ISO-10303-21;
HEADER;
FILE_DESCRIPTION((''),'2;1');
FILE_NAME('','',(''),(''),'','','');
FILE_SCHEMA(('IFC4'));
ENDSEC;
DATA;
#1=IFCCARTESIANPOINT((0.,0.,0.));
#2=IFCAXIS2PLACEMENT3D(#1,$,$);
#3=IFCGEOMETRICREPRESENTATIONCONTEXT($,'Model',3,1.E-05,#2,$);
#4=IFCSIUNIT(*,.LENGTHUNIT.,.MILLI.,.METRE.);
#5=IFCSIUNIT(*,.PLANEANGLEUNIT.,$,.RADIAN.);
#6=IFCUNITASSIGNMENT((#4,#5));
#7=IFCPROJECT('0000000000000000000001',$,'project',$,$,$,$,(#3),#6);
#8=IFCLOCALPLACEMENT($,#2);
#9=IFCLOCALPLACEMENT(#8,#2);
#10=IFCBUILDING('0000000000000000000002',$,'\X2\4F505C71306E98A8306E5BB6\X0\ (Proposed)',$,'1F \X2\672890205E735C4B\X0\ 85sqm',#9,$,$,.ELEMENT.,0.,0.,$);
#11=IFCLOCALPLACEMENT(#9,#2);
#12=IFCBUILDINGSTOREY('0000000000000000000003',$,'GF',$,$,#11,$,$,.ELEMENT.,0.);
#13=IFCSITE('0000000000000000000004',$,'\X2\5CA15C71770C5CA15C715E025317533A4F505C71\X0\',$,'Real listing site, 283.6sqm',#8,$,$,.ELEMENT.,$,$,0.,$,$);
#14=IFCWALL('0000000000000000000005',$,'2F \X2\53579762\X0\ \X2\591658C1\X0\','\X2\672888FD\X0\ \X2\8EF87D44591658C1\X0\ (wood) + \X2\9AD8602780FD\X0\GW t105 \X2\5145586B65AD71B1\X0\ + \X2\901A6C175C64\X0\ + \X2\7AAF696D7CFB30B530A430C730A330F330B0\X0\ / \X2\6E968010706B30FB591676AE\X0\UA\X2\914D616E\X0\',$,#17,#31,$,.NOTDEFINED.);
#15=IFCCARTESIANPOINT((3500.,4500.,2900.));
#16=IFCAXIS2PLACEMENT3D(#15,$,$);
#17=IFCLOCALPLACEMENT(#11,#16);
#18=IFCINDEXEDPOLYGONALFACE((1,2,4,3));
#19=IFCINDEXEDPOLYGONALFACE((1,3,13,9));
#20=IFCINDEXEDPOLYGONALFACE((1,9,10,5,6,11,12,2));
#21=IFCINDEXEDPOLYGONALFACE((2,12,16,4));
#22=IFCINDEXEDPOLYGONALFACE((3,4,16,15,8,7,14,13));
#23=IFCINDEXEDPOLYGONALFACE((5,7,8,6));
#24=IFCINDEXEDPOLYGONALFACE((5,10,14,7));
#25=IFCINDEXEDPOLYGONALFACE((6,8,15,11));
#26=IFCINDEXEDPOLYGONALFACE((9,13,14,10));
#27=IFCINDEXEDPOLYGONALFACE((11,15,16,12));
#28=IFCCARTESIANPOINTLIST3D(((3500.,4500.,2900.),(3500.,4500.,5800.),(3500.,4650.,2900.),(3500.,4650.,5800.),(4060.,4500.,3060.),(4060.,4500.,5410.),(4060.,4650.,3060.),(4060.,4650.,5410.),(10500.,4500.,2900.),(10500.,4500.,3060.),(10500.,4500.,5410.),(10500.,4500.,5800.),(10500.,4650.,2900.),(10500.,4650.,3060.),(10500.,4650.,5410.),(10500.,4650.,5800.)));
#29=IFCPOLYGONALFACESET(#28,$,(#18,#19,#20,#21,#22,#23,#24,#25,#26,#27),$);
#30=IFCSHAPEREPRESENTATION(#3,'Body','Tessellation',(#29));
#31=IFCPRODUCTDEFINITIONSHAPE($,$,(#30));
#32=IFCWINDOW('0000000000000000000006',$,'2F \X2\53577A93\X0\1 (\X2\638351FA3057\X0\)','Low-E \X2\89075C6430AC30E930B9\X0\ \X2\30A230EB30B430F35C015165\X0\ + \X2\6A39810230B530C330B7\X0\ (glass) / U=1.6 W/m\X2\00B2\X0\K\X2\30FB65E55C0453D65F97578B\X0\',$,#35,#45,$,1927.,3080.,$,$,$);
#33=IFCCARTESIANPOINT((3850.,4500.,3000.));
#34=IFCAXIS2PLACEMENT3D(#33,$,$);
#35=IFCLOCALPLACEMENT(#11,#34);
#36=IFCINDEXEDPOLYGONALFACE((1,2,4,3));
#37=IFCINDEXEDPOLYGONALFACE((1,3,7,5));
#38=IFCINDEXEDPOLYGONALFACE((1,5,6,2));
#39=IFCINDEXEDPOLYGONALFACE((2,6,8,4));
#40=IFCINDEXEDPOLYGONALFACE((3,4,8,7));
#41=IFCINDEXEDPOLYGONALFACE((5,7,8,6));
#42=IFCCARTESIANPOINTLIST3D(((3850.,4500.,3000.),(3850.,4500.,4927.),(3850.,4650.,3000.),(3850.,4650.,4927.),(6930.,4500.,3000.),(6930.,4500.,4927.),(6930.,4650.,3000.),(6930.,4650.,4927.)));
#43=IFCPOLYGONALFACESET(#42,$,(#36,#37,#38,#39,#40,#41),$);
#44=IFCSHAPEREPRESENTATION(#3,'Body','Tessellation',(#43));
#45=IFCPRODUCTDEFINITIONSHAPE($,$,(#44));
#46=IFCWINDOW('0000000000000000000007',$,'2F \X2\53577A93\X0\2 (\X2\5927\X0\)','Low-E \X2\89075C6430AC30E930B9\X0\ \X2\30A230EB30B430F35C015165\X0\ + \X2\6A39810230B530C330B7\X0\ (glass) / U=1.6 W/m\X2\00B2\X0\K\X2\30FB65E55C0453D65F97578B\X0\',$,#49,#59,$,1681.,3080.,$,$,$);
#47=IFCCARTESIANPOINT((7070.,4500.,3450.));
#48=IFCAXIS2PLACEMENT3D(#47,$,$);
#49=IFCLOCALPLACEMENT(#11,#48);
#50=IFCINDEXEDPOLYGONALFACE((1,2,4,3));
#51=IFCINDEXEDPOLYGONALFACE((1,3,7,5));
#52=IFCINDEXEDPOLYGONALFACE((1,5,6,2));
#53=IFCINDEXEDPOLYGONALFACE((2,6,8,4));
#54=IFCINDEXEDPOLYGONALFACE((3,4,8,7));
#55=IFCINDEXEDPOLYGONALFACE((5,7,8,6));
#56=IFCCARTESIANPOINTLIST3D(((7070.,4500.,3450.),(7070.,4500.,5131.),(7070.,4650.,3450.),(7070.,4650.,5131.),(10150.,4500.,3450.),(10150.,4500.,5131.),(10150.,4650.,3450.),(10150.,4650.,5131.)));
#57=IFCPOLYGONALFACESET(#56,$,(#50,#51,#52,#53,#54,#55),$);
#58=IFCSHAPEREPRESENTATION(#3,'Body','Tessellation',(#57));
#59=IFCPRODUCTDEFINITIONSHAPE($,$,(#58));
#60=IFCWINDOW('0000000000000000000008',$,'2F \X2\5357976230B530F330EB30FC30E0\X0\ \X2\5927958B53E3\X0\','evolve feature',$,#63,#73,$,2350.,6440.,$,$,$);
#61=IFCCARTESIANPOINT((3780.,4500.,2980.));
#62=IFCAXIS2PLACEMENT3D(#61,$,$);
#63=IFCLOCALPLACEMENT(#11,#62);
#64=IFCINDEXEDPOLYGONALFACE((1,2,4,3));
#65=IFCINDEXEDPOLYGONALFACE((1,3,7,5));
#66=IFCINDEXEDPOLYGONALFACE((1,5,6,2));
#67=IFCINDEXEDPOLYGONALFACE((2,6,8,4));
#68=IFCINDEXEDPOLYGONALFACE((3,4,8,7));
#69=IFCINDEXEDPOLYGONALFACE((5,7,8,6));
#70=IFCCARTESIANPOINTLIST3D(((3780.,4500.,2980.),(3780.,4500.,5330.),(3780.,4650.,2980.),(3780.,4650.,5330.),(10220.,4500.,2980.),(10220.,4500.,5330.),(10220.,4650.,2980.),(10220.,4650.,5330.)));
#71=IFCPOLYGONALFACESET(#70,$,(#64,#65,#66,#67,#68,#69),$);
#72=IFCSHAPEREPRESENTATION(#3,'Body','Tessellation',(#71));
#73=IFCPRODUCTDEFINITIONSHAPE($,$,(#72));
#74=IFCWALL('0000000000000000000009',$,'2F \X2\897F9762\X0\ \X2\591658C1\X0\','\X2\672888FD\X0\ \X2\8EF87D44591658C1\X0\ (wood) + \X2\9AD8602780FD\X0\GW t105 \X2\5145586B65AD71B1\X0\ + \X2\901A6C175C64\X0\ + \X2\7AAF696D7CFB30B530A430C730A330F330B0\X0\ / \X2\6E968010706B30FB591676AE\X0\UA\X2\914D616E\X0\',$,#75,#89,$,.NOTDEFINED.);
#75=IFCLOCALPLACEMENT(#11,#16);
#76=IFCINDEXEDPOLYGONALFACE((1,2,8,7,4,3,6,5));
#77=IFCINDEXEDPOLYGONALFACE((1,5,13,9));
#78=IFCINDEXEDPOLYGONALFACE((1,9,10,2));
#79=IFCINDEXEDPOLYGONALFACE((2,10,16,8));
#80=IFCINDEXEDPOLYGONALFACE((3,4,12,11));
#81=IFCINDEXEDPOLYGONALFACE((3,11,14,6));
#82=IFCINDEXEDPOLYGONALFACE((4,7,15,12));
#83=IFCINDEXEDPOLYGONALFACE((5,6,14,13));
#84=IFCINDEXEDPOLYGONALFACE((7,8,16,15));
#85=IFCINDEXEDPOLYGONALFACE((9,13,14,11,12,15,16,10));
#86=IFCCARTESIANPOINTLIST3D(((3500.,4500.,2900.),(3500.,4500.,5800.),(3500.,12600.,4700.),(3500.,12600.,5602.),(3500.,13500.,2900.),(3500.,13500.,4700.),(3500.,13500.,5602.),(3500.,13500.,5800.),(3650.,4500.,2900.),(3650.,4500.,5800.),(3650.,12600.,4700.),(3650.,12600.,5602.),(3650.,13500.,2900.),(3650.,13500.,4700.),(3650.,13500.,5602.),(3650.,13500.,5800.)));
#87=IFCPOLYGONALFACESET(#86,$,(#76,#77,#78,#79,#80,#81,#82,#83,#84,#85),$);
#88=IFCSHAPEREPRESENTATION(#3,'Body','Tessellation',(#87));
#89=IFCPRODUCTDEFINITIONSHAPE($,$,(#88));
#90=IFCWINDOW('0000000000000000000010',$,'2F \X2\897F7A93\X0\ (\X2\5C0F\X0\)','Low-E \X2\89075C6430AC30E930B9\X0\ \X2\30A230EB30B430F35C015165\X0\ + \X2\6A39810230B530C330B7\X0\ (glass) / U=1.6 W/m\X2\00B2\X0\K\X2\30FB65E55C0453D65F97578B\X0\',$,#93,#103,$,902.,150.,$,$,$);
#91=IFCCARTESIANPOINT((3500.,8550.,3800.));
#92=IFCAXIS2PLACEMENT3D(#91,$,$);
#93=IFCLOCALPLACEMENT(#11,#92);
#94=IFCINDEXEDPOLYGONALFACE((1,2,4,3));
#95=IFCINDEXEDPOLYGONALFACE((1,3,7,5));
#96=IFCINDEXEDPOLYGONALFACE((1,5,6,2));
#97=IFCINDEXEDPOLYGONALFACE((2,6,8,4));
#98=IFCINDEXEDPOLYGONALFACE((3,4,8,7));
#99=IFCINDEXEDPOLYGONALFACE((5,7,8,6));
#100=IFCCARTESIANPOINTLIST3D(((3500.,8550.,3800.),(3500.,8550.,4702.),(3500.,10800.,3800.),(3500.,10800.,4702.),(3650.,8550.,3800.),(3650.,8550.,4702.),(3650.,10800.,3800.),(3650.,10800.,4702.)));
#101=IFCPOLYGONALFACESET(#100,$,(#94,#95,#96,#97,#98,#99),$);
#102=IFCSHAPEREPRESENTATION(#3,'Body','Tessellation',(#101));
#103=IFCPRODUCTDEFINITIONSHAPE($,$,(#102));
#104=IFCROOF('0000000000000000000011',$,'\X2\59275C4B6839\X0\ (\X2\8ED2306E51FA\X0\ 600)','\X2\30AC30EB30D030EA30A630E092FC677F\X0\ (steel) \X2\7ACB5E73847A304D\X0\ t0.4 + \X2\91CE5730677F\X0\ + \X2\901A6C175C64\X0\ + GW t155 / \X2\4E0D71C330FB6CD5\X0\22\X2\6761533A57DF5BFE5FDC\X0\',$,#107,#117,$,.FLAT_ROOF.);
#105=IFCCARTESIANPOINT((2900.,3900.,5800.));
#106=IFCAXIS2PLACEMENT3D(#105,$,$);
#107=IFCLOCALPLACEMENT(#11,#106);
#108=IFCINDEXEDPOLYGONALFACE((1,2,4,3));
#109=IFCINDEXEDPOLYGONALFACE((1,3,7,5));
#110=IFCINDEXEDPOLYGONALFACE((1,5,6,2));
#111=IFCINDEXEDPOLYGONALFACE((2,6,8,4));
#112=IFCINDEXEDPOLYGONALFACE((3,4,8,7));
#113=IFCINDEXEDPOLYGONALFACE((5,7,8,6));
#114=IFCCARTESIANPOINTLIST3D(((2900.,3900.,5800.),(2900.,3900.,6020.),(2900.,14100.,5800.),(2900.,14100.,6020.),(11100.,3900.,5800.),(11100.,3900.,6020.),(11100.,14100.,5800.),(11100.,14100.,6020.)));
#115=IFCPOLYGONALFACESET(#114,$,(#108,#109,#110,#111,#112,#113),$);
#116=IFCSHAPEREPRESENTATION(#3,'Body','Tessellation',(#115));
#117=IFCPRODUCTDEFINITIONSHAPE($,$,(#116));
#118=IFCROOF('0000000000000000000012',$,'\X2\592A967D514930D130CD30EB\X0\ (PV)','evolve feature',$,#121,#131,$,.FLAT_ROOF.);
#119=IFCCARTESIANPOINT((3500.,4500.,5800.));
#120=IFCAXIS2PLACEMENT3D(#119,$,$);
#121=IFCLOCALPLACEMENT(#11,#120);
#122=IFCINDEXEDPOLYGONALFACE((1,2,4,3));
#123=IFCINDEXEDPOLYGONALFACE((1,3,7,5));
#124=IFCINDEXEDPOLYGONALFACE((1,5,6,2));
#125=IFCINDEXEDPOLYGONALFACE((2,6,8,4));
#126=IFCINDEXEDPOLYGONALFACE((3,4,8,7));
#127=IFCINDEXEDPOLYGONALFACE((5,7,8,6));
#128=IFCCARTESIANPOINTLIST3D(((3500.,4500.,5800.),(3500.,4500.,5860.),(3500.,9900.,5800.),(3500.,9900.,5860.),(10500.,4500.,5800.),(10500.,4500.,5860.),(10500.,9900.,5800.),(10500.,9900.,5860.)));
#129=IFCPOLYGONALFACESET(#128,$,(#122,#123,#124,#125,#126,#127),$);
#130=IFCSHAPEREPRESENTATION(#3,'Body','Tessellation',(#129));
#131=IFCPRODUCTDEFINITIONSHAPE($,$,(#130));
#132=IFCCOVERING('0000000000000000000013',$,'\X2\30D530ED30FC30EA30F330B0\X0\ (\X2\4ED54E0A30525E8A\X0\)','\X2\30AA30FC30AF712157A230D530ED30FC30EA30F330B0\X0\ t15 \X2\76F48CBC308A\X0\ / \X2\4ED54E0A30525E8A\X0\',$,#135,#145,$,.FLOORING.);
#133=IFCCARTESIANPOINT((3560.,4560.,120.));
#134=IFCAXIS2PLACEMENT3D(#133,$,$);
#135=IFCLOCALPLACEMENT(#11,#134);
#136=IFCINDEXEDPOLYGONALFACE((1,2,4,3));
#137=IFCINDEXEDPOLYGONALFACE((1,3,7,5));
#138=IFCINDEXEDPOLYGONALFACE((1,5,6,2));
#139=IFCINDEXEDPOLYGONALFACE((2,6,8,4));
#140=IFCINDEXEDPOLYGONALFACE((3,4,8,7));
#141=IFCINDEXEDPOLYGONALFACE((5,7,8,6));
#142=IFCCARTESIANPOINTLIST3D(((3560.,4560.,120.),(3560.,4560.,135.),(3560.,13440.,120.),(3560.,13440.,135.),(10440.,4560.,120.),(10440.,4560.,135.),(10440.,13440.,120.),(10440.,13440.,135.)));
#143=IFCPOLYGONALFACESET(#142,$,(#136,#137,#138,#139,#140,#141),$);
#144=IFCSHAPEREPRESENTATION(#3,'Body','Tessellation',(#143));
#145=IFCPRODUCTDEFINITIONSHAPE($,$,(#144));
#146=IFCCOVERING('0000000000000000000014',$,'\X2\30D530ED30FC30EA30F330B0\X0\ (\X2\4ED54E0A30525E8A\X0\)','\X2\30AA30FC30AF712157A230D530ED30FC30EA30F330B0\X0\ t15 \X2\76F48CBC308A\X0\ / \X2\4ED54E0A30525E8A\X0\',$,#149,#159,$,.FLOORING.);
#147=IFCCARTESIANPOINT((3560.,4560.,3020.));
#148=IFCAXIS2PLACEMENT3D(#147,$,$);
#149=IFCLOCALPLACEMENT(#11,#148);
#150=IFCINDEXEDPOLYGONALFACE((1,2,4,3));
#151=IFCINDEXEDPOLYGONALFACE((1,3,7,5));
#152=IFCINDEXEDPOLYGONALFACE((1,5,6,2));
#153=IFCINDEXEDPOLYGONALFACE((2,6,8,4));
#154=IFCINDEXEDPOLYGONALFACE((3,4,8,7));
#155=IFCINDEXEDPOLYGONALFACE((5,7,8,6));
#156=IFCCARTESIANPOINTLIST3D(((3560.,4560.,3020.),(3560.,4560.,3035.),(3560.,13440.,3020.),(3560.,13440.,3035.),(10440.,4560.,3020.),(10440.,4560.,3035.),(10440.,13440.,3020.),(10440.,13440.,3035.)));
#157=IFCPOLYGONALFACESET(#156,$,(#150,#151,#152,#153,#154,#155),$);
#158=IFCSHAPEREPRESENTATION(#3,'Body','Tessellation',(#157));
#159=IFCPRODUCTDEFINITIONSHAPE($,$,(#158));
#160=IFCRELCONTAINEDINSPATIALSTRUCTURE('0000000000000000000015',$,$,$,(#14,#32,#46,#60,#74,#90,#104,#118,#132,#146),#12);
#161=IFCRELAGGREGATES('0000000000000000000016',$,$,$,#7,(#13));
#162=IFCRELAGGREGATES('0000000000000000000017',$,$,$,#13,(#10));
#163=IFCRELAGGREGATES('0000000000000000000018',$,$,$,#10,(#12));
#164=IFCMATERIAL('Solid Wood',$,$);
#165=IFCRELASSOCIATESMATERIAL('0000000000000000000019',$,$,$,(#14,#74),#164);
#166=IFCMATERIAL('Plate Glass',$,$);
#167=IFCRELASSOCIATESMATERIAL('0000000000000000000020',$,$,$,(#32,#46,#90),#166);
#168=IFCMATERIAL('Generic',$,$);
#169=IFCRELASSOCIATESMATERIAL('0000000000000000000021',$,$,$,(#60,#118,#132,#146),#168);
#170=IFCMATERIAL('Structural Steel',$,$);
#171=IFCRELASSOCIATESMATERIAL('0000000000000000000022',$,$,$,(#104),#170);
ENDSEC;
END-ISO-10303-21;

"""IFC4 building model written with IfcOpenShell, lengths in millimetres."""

from ifc_helpers import new_model, si_unit, frame, frame_2d, origin, place, context, project, spatial, rectangle, extrude, material, element, fill, save


model = new_model("IFC4")

# Units and contexts
model_context = context("Model", 3, precision=1e-05, world=origin())
ifc_project = project(units=[si_unit("LENGTHUNIT", "METRE", prefix="MILLI"), si_unit("PLANEANGLEUNIT", "RADIAN")], contexts=[model_context])

# Site, building, storey
site_placement = place(None, origin())
site = spatial("IfcSite", under=ifc_project, at=site_placement, Name="岡山県岡山市北区佐山", ObjectType="Real listing site, 283.6sqm", CompositionType="ELEMENT", RefElevation=0.0)
building_placement = place(site_placement, origin())
building = spatial("IfcBuilding", under=site, at=building_placement, Name="佐山の風の家 (Proposed)", ObjectType="1F 木造平屋 85sqm", CompositionType="ELEMENT", ElevationOfRefHeight=0.0, ElevationOfTerrain=0.0)
storey_placement = place(building_placement, origin())
storey = spatial("IfcBuildingStorey", under=building, at=storey_placement, Name="GF", CompositionType="ELEMENT", Elevation=0.0)

# Shared definitions
ifc_material_1 = material(Name="Solid Wood")
ifc_material_2 = material(Name="Generic")

# Shared definitions
ifc_material_3 = material(Name="Plate Glass")

# Wall, openings, windows
wall_1_placement = place(storey_placement, frame((3500.0, 4500.0, 2900.0)))
wall_1 = element("IfcWall", 1, at=wall_1_placement, inside=storey, material=ifc_material_1, Name="2F 南面 外壁", Description="木製 軸組外壁 (wood) + 高性能GW t105 充填断熱 + 通気層 + 窯業系サイディング / 準耐火・外皮UA配慮", PredefinedType="NOTDEFINED", context=model_context, shape_type="SweptSolid", body=[
    extrude(rectangle(XDim=7000.0, YDim=150.0, at=frame_2d((3500.0, 75.0))), frame((3500.0, 4500.0, 2900.0)), (0.0, 0.0, 1.0), 2900.0),
])
opening_1_placement = place(storey_placement, frame((3850.0, 4500.0, 3000.0)))
opening_1 = element("IfcOpeningElement", 2, at=opening_1_placement, cuts=wall_1, PredefinedType="NOTDEFINED", context=model_context, shape_type="SweptSolid", body=[
    extrude(rectangle(XDim=3080.0, YDim=150.0, at=frame_2d((1540.0, 75.0))), frame((3850.0, 4500.0, 3000.0)), (0.0, 0.0, 1.0), 1927.0),
])
opening_2_placement = place(storey_placement, frame((7070.0, 4500.0, 3450.0)))
opening_2 = element("IfcOpeningElement", 3, at=opening_2_placement, cuts=wall_1, PredefinedType="NOTDEFINED", context=model_context, shape_type="SweptSolid", body=[
    extrude(rectangle(XDim=3080.0, YDim=150.0, at=frame_2d((1540.0, 75.0))), frame((7070.0, 4500.0, 3450.0)), (0.0, 0.0, 1.0), 1681.0),
])
opening_3_placement = place(storey_placement, frame((3780.0, 4500.0, 2980.0)))
opening_3 = element("IfcOpeningElement", 4, at=opening_3_placement, cuts=wall_1, PredefinedType="NOTDEFINED", context=model_context, shape_type="SweptSolid", body=[
    extrude(rectangle(XDim=6440.0, YDim=150.0, at=frame_2d((3220.0, 75.0))), frame((3780.0, 4500.0, 2980.0)), (0.0, 0.0, 1.0), 2350.0),
])
window_1_placement = place(storey_placement, frame((3850.0, 4500.0, 3000.0)))
window_1 = element("IfcWindow", 5, at=window_1_placement, inside=storey, material=ifc_material_3, Name="2F 南窓1 (掃出し)", Description="Low-E 複層ガラス アルゴン封入 + 樹脂サッシ (glass) / U=1.6 W/m²K・日射取得型", OverallHeight=1927.0, OverallWidth=3080.0, context=model_context, shape_type="SweptSolid", body=[
    extrude(rectangle(XDim=3080.0, YDim=150.0, at=frame_2d((1540.0, 75.0))), frame((3850.0, 4500.0, 3000.0)), (0.0, 0.0, 1.0), 1927.0),
])
fill(opening_1, window_1)
window_2_placement = place(storey_placement, frame((7070.0, 4500.0, 3450.0)))
window_2 = element("IfcWindow", 6, at=window_2_placement, inside=storey, material=ifc_material_3, Name="2F 南窓2 (大)", Description="Low-E 複層ガラス アルゴン封入 + 樹脂サッシ (glass) / U=1.6 W/m²K・日射取得型", OverallHeight=1681.0, OverallWidth=3080.0, context=model_context, shape_type="SweptSolid", body=[
    extrude(rectangle(XDim=3080.0, YDim=150.0, at=frame_2d((1540.0, 75.0))), frame((7070.0, 4500.0, 3450.0)), (0.0, 0.0, 1.0), 1681.0),
])
fill(opening_2, window_2)
window_3_placement = place(storey_placement, frame((3780.0, 4500.0, 2980.0)))
window_3 = element("IfcWindow", 7, at=window_3_placement, inside=storey, material=ifc_material_2, Name="2F 南面サンルーム 大開口", Description="evolve feature", OverallHeight=2350.0, OverallWidth=6440.0, context=model_context, shape_type="SweptSolid", body=[
    extrude(rectangle(XDim=6440.0, YDim=150.0, at=frame_2d((3220.0, 75.0))), frame((3780.0, 4500.0, 2980.0)), (0.0, 0.0, 1.0), 2350.0),
])
fill(opening_3, window_3)

# Wall, opening, window
wall_2_placement = place(storey_placement, frame((3500.0, 4500.0, 2900.0)))
wall_2 = element("IfcWall", 8, at=wall_2_placement, inside=storey, material=ifc_material_1, Name="2F 西面 外壁", Description="木製 軸組外壁 (wood) + 高性能GW t105 充填断熱 + 通気層 + 窯業系サイディング / 準耐火・外皮UA配慮", PredefinedType="NOTDEFINED", context=model_context, shape_type="SweptSolid", body=[
    extrude(rectangle(XDim=150.0, YDim=9000.0, at=frame_2d((75.0, 4500.0))), frame((3500.0, 4500.0, 2900.0)), (0.0, 0.0, 1.0), 2900.0),
])
opening_4_placement = place(storey_placement, frame((3500.0, 8550.0, 3800.0)))
opening_4 = element("IfcOpeningElement", 9, at=opening_4_placement, cuts=wall_2, PredefinedType="NOTDEFINED", context=model_context, shape_type="SweptSolid", body=[
    extrude(rectangle(XDim=150.0, YDim=2250.0, at=frame_2d((75.0, 1125.0))), frame((3500.0, 8550.0, 3800.0)), (0.0, 0.0, 1.0), 902.0),
])
window_4_placement = place(storey_placement, frame((3500.0, 8550.0, 3800.0)))
window_4 = element("IfcWindow", 10, at=window_4_placement, inside=storey, material=ifc_material_3, Name="2F 西窓 (小)", Description="Low-E 複層ガラス アルゴン封入 + 樹脂サッシ (glass) / U=1.6 W/m²K・日射取得型", OverallHeight=902.0, OverallWidth=150.0, context=model_context, shape_type="SweptSolid", body=[
    extrude(rectangle(XDim=150.0, YDim=2250.0, at=frame_2d((75.0, 1125.0))), frame((3500.0, 8550.0, 3800.0)), (0.0, 0.0, 1.0), 902.0),
])
fill(opening_4, window_4)

# Roofs
ifc_material_4 = material(Name="Structural Steel")
roof_1_placement = place(storey_placement, frame((2900.0, 3900.0, 5800.0)))
element("IfcRoof", 11, at=roof_1_placement, inside=storey, material=ifc_material_4, Name="大屋根 (軒の出 600)", Description="ガルバリウム鋼板 (steel) 立平葺き t0.4 + 野地板 + 通気層 + GW t155 / 不燃・法22条区域対応", PredefinedType="FLAT_ROOF", context=model_context, shape_type="SweptSolid", body=[
    extrude(rectangle(XDim=8200.0, YDim=10200.0, at=frame_2d((4100.0, 5100.0))), frame((2900.0, 3900.0, 5800.0)), (0.0, 0.0, 1.0), 220.0),
])
roof_2_placement = place(storey_placement, frame((3500.0, 4500.0, 5800.0)))
element("IfcRoof", 12, at=roof_2_placement, inside=storey, material=ifc_material_2, Name="太陽光パネル (PV)", Description="evolve feature", PredefinedType="FLAT_ROOF", context=model_context, shape_type="SweptSolid", body=[
    extrude(rectangle(XDim=7000.0, YDim=5400.0, at=frame_2d((3500.0, 2700.0))), frame((3500.0, 4500.0, 5800.0)), (0.0, 0.0, 1.0), 60.0),
])

# Coverings
covering_1_placement = place(storey_placement, frame((3560.0, 4560.0, 120.0)))
element("IfcCovering", 13, at=covering_1_placement, inside=storey, material=ifc_material_2, Name="フローリング (仕上げ床)", Description="オーク無垢フローリング t15 直貼り / 仕上げ床", PredefinedType="FLOORING", context=model_context, shape_type="SweptSolid", body=[
    extrude(rectangle(XDim=6880.0, YDim=8880.0, at=frame_2d((3440.0, 4440.0))), frame((3560.0, 4560.0, 120.0)), (0.0, 0.0, 1.0), 15.0),
])
covering_2_placement = place(storey_placement, frame((3560.0, 4560.0, 3020.0)))
element("IfcCovering", 14, at=covering_2_placement, inside=storey, material=ifc_material_2, Name="フローリング (仕上げ床)", Description="オーク無垢フローリング t15 直貼り / 仕上げ床", PredefinedType="FLOORING", context=model_context, shape_type="SweptSolid", body=[
    extrude(rectangle(XDim=6880.0, YDim=8880.0, at=frame_2d((3440.0, 4440.0))), frame((3560.0, 4560.0, 3020.0)), (0.0, 0.0, 1.0), 15.0),
])

save(model, "model.ifc")
